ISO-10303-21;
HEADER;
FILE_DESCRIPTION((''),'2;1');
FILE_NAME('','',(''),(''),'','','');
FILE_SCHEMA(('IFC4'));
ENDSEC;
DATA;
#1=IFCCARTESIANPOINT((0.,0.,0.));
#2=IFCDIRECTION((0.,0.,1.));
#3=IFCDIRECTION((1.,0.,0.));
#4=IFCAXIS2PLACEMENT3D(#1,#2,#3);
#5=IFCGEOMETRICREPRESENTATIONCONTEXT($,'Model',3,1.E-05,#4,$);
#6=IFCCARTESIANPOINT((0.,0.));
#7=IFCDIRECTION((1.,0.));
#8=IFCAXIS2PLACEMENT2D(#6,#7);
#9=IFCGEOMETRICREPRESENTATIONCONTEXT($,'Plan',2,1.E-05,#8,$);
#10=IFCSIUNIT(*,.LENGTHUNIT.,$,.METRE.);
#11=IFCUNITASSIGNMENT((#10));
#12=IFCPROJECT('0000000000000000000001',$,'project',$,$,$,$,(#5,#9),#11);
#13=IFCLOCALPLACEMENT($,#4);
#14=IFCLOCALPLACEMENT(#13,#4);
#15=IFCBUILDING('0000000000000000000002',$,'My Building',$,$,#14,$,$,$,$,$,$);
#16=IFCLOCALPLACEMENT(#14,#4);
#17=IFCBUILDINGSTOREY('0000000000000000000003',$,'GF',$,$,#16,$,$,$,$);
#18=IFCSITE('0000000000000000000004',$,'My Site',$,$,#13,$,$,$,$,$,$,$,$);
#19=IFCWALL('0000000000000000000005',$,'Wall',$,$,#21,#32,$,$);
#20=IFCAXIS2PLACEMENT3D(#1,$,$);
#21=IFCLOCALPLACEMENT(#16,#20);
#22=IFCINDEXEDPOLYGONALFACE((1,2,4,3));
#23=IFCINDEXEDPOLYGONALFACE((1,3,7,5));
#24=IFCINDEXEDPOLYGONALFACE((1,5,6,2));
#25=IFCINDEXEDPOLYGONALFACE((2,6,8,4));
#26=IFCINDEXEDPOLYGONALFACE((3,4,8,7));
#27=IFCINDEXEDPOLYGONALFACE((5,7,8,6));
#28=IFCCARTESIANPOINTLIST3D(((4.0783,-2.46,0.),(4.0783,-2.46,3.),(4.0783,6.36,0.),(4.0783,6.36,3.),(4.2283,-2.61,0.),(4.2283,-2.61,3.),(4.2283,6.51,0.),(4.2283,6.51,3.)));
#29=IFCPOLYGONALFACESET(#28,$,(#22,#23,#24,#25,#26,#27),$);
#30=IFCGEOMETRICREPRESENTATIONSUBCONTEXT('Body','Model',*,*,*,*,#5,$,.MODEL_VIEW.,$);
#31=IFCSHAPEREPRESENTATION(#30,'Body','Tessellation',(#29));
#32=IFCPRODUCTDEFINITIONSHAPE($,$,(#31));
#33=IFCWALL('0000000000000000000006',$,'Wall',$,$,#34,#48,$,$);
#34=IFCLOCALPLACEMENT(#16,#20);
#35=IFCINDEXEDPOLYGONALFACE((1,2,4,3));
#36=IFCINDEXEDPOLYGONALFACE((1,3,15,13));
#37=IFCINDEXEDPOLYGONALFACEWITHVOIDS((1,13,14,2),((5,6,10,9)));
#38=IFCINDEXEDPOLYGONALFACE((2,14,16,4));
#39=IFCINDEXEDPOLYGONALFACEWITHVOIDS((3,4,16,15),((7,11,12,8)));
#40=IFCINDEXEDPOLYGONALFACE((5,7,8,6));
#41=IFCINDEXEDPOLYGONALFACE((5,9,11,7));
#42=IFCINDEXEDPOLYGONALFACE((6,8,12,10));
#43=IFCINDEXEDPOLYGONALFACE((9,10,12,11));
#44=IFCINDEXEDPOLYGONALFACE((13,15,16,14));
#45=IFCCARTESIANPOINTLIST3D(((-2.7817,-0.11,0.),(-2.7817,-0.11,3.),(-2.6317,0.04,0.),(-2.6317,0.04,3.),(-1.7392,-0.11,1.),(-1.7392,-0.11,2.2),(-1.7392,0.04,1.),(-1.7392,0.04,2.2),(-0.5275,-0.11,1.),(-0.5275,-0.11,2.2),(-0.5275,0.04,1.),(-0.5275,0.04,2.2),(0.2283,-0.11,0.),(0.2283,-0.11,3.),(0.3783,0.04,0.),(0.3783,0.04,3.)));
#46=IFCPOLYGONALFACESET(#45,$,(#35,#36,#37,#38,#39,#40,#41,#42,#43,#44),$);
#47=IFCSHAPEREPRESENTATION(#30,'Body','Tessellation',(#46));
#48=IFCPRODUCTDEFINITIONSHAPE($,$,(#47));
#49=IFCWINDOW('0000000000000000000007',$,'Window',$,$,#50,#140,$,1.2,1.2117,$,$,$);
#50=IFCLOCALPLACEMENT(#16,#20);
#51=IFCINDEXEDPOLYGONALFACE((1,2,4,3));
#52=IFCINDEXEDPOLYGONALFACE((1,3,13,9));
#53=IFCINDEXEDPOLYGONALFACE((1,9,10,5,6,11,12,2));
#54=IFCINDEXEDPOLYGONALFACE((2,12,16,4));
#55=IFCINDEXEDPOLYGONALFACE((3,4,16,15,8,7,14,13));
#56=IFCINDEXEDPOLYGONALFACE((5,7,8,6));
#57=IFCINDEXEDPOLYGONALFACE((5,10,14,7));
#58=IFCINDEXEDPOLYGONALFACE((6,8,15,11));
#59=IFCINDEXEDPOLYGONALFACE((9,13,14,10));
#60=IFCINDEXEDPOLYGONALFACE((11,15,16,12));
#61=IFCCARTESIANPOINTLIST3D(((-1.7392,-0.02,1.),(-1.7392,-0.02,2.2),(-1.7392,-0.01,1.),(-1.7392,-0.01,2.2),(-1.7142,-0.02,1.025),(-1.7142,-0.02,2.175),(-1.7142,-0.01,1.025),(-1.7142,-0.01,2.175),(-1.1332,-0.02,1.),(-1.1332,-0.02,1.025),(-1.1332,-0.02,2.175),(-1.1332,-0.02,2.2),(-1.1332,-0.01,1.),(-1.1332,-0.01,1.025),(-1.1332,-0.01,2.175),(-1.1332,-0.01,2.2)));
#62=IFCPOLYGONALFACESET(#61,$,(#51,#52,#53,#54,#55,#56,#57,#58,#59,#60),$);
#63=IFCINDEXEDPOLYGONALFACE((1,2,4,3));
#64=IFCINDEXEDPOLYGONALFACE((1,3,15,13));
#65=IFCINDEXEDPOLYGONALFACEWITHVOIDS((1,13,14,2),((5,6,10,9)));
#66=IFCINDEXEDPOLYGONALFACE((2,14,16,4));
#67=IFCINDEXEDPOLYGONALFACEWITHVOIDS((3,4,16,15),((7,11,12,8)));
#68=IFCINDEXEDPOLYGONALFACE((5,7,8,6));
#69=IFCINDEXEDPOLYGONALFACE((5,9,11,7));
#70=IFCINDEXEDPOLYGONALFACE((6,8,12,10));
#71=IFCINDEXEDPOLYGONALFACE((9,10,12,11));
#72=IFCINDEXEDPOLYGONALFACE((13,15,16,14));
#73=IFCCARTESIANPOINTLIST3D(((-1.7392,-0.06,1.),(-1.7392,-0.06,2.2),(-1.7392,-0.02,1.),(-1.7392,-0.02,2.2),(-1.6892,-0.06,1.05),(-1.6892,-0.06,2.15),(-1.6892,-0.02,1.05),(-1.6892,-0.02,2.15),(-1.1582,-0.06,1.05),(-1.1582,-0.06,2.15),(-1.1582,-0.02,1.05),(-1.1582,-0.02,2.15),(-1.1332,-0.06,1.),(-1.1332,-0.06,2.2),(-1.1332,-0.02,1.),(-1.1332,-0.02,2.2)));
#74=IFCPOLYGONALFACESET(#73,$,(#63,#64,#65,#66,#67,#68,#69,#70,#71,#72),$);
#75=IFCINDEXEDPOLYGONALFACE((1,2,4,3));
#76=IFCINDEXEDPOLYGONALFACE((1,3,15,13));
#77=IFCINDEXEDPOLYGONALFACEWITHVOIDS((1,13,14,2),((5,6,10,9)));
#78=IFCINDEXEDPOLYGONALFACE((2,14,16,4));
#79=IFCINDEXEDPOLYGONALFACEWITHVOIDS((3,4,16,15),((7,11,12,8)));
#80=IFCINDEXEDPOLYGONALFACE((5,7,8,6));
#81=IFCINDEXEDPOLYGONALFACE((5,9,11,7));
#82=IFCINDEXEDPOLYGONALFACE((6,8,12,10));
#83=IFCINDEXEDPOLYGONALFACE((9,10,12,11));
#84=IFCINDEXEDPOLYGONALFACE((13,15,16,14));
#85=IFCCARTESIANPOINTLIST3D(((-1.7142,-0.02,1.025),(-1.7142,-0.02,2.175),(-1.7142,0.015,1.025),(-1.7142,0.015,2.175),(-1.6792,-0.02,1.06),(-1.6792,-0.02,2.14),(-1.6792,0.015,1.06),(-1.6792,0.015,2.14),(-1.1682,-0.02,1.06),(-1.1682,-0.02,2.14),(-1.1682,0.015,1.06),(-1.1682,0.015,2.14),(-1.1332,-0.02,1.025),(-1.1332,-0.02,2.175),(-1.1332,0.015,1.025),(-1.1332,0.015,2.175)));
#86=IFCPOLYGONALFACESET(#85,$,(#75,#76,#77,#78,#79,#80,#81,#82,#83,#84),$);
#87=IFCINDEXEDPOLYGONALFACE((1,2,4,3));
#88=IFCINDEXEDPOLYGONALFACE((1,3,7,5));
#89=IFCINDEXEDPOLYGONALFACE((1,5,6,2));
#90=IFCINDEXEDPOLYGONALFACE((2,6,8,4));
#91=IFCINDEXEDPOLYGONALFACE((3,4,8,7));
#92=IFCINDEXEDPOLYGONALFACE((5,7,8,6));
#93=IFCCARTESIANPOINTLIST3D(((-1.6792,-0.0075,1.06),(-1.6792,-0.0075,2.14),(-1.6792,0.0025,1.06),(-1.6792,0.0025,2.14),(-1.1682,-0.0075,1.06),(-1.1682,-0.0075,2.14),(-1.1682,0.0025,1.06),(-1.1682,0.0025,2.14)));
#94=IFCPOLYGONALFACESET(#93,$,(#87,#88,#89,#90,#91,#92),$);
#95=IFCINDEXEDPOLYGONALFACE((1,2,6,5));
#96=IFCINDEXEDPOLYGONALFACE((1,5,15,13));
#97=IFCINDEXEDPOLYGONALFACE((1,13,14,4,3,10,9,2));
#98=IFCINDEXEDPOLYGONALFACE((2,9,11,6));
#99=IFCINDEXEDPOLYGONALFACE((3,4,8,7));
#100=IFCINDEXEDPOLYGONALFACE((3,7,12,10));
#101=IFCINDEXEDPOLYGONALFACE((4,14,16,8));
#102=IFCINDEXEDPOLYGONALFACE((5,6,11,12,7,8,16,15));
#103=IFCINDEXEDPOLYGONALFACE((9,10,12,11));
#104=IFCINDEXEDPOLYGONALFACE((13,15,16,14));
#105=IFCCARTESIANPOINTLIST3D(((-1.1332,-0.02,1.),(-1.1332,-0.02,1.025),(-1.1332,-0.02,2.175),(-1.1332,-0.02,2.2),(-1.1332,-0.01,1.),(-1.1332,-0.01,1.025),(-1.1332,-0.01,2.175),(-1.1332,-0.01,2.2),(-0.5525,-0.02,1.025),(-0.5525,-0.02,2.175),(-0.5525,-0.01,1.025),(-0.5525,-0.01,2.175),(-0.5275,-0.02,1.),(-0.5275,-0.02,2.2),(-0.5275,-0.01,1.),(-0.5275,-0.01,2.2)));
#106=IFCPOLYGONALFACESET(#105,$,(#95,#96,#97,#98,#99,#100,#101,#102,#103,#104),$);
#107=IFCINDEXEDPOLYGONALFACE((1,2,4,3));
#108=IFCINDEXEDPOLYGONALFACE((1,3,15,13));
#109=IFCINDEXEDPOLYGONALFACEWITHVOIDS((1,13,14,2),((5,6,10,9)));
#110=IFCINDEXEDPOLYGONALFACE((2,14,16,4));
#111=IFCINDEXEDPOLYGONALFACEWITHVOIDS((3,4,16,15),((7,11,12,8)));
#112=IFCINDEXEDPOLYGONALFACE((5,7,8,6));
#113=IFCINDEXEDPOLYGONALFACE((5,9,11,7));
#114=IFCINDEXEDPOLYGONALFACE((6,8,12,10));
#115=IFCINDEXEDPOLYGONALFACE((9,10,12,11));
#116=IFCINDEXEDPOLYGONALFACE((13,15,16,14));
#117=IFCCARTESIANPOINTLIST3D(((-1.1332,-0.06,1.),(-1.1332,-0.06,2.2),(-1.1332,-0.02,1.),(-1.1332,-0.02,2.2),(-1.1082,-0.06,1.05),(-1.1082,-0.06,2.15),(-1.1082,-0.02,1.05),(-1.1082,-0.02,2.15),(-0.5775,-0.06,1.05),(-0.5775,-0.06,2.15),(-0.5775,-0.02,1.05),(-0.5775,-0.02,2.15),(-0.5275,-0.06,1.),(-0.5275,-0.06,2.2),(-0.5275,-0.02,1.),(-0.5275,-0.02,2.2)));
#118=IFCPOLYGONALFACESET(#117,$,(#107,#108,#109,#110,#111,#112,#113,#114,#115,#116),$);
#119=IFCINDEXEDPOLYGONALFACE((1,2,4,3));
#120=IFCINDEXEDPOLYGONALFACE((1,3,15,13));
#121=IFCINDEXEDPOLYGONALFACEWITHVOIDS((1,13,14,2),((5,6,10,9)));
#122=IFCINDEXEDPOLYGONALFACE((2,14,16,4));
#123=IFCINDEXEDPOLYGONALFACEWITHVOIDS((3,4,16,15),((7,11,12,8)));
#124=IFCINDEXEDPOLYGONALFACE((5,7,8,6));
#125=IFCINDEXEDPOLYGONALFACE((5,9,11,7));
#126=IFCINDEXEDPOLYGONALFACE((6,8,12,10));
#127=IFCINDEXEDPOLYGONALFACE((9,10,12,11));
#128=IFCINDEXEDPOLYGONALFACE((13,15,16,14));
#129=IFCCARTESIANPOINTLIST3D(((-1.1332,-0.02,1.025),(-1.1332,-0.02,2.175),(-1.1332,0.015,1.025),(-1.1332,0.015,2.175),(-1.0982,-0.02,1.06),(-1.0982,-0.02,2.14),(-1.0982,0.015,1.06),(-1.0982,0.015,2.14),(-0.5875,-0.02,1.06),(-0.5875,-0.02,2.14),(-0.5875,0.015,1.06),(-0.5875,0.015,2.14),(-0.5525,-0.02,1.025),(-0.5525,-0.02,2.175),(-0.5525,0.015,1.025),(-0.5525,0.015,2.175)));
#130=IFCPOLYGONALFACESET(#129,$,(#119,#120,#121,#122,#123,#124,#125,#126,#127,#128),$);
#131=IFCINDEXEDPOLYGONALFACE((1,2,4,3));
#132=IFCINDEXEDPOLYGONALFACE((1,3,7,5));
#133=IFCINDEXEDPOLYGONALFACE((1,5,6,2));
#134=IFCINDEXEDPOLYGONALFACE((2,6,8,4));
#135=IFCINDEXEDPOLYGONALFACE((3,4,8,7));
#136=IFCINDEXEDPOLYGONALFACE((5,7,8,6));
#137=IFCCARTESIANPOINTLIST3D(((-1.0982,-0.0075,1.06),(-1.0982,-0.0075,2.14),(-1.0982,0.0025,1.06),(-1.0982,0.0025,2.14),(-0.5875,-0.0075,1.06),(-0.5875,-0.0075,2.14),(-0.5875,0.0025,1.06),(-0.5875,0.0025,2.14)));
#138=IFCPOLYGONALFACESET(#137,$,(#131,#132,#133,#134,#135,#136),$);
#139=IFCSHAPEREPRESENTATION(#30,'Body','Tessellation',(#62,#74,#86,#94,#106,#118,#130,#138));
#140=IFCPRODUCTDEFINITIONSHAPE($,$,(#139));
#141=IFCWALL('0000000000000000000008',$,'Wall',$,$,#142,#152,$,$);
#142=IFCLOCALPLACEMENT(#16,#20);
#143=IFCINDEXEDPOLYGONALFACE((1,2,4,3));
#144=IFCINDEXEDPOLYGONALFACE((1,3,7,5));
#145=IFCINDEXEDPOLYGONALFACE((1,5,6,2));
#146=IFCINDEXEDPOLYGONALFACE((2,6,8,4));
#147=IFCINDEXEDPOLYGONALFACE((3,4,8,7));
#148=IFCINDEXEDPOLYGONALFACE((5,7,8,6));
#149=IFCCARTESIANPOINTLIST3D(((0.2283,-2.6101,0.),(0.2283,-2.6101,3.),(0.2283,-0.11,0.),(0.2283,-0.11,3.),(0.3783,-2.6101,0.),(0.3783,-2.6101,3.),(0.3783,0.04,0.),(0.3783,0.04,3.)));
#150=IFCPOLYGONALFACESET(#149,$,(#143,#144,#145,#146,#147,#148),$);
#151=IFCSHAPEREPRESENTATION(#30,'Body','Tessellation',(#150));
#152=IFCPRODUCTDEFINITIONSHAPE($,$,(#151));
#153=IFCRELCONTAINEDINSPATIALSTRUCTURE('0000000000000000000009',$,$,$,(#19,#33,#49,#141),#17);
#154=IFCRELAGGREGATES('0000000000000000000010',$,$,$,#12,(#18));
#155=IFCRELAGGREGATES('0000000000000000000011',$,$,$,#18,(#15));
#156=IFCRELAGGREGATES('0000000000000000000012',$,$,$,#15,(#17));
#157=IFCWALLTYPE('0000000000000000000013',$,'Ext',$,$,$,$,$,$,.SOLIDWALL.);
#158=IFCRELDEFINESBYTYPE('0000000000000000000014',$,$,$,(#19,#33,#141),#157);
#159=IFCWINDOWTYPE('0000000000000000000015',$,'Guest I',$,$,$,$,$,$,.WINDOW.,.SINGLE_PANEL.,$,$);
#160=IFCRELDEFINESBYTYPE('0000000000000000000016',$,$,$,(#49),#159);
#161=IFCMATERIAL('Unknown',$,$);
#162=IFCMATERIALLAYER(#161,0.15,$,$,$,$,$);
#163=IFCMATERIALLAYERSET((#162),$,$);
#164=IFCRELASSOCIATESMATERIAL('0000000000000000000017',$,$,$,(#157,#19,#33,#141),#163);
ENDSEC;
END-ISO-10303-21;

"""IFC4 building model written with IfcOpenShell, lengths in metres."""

from ifc_helpers import new_model, entity, si_unit, frame, origin_with_axes, origin_2d_with_axis, place, context, subcontext, project, spatial, line, indexed_curve, outline, extrude, shape, source, transform, mapped, material, layer, layer_set, layer_usage, type_object, type_shapes, element, fill, save


model = new_model("IFC4")

# Units and contexts
model_context = context("Model", 3, precision=1e-05, world=origin_with_axes())
plan_context = context("Plan", 2, precision=1e-05, world=origin_2d_with_axis())
body_context_1 = subcontext(model_context, "Body", "Model", "MODEL_VIEW")
body_context_2 = subcontext(plan_context, "Body", "Plan", "PLAN_VIEW")
ifc_project = project(units=[si_unit("LENGTHUNIT", "METRE")], contexts=[model_context, plan_context])

# Site, building, storey
site_placement = place(None, origin_with_axes())
site = spatial("IfcSite", under=ifc_project, at=site_placement, Name="My Site")
building_placement = place(site_placement, origin_with_axes())
building = spatial("IfcBuilding", under=site, at=building_placement, Name="My Building")
storey_placement = place(building_placement, origin_with_axes())
storey = spatial("IfcBuildingStorey", under=building, at=storey_placement, Name="GF")

# Shared definitions
ifc_material = material(Name="Unknown")

# Shared definitions
ifc_layer_1 = layer(ifc_material, 0.15)
ifc_layer_set_1 = layer_set([ifc_layer_1])
wall_type = type_object("IfcWallType", Name="Ext", PredefinedType="SOLIDWALL", material=ifc_layer_set_1)

# Wall
ifc_layer_usage_1 = layer_usage(ifc_layer_set_1, "AXIS2", "POSITIVE", 0.0)
wall_1_placement = place(storey_placement, frame((4.2283, -2.61, 0.0), z_axis=(0.0, 0.0, 1.0), x_axis=(0.0, 1.0, 0.0)))
element("IfcWall", 1, at=wall_1_placement, inside=storey, type_object=wall_type, material=ifc_layer_usage_1, Name="Wall", context=body_context_1, shape_type="SweptSolid", body=[
    extrude(outline(indexed_curve([(0.0, 0.0), (0.15, 0.15), (8.97, 0.15), (9.12, 0.0)], segments=[line(1, 2, 3, 4, 1)])), origin_with_axes(), (0.0, 0.0, 1.0), 3.0),
])

# Wall, opening, window
ifc_layer_usage_2 = layer_usage(ifc_layer_set_1, "AXIS2", "POSITIVE", 0.0)
wall_2_placement = place(storey_placement, frame((-2.7817, -0.11, 0.0), z_axis=(0.0, 0.0, 1.0), x_axis=(1.0, 0.0, 0.0)))
wall_2 = element("IfcWall", 2, at=wall_2_placement, inside=storey, type_object=wall_type, material=ifc_layer_usage_2, Name="Wall", context=body_context_1, shape_type="SweptSolid", body=[
    extrude(outline(indexed_curve([(0.0, 0.0), (0.15, 0.15), (3.16, 0.15), (3.01, 0.0)], segments=[line(1, 2, 3, 4, 1)])), origin_with_axes(), (0.0, 0.0, 1.0), 3.0),
])
shared_shape_1 = source(origin_with_axes(), body_context_1, "Body", "SweptSolid", [
    extrude(outline(indexed_curve([(0.0, 0.0), (1.2117, 0.0), (1.2117, 1.2), (0.0, 1.2)], segments=[line(1, 2, 3, 4, 1)])), frame((0.0, -0.6, 0.0), z_axis=(0.0, -1.0, 0.0), x_axis=(1.0, 0.0, 0.0)), (0.0, 0.0, -1.0), 1.2),
])
opening_1_placement = place(wall_2_placement, frame((1.0425, 0.0, 1.0), z_axis=(0.0, 0.0, 1.0), x_axis=(1.0, 0.0, 0.0)))
opening_1 = element("IfcOpeningElement", 3, at=opening_1_placement, cuts=wall_2, PredefinedType="OPENING", context=body_context_1, shape_type="MappedRepresentation", body=[
    mapped(shared_shape_1, transform((0.0, 0.0, 0.0), x_axis=(1.0, 0.0, 0.0), y_axis=(0.0, 1.0, 0.0), z_axis=(0.0, 0.0, 1.0), scale=1.0)),
])
window_type_1 = type_object("IfcWindowType", Name="Guest I", PartitioningType="SINGLE_PANEL", PredefinedType="WINDOW")
shared_shape_2 = source(origin_with_axes(), body_context_1, "Body", "SweptSolid", [
    extrude(outline(indexed_curve([(0.606, 0.0), (0.0, 0.0), (0.0, 1.2), (0.606, 1.2), (0.606, 1.175), (0.025, 1.175), (0.025, 0.025), (0.606, 0.025)], segments=[line(1, 2, 3, 4, 5, 6, 7, 8, 1)])), frame((0.0, 0.09, 0.0), z_axis=(0.0, -1.0, 0.0), x_axis=(1.0, 0.0, 0.0)), (0.0, 0.0, -1.0), 0.01),
    extrude(outline(indexed_curve([(0.0, 1.2), (0.606, 1.2), (0.606, 0.0), (0.0, 0.0), (0.0, 1.2)]), holes=[indexed_curve([(0.05, 1.15), (0.581, 1.15), (0.581, 0.05), (0.05, 0.05), (0.05, 1.15)])]), frame((0.0, 0.05, 0.0), z_axis=(0.0, -1.0, 0.0), x_axis=(1.0, 0.0, 0.0)), (0.0, 0.0, -1.0), 0.04),
    extrude(outline(indexed_curve([(0.0, 0.0), (0.581, 0.0), (0.581, 1.15), (0.0, 1.15)], segments=[line(1, 2, 3, 4, 1)]), holes=[indexed_curve([(0.035, 0.035), (0.546, 0.035), (0.546, 1.115), (0.035, 1.115)], segments=[line(1, 2, 3, 4, 1)])]), frame((0.025, 0.09, 0.025), z_axis=(0.0, -1.0, 0.0), x_axis=(1.0, 0.0, 0.0)), (0.0, 0.0, -1.0), 0.035),
    extrude(outline(indexed_curve([(0.035, 0.035), (0.546, 0.035), (0.546, 1.115), (0.035, 1.115)], segments=[line(1, 2, 3, 4, 1)])), frame((0.025, 0.1025, 0.025), z_axis=(0.0, -1.0, 0.0), x_axis=(1.0, 0.0, 0.0)), (0.0, 0.0, -1.0), 0.01),
    extrude(outline(indexed_curve([(0.0, 1.2), (0.6057, 1.2), (0.6057, 0.0), (0.0, 0.0), (0.0, 0.025), (0.5807, 0.025), (0.5807, 1.175), (0.0, 1.175)], segments=[line(1, 2, 3, 4, 5, 6, 7, 8, 1)])), frame((0.606, 0.09, 0.0), z_axis=(0.0, -1.0, 0.0), x_axis=(1.0, 0.0, 0.0)), (0.0, 0.0, -1.0), 0.01),
    extrude(outline(indexed_curve([(0.0, 0.0), (0.6057, 0.0), (0.6057, 1.2), (0.0, 1.2)], segments=[line(1, 2, 3, 4, 1)]), holes=[indexed_curve([(0.025, 0.05), (0.5557, 0.05), (0.5557, 1.15), (0.025, 1.15)], segments=[line(1, 2, 3, 4, 1)])]), frame((0.606, 0.05, 0.0), z_axis=(0.0, -1.0, 0.0), x_axis=(1.0, 0.0, 0.0)), (0.0, 0.0, -1.0), 0.04),
    extrude(outline(indexed_curve([(0.0, 0.0), (0.5807, 0.0), (0.5807, 1.15), (0.0, 1.15)], segments=[line(1, 2, 3, 4, 1)]), holes=[indexed_curve([(0.035, 0.035), (0.5457, 0.035), (0.5457, 1.115), (0.035, 1.115)], segments=[line(1, 2, 3, 4, 1)])]), frame((0.606, 0.09, 0.025), z_axis=(0.0, -1.0, 0.0), x_axis=(1.0, 0.0, 0.0)), (0.0, 0.0, -1.0), 0.035),
    extrude(outline(indexed_curve([(0.035, 0.035), (0.5457, 0.035), (0.5457, 1.115), (0.035, 1.115)], segments=[line(1, 2, 3, 4, 1)])), frame((0.606, 0.1025, 0.025), z_axis=(0.0, -1.0, 0.0), x_axis=(1.0, 0.0, 0.0)), (0.0, 0.0, -1.0), 0.01),
])
shared_shape_3 = source(origin_with_axes(), body_context_2, "Body", "Curve2D", [
    entity("IfcIndexedPolyCurve", entity("IfcCartesianPointList2D", [[0.05, 0.05], [0.581, 0.05]])),
    entity("IfcIndexedPolyCurve", entity("IfcCartesianPointList2D", [[0.0, 0.1], [0.025, 0.1], [0.025, 0.09], [0.05, 0.09], [0.05, 0.05], [0.0, 0.05]]), [entity("IfcLineIndex", [1, 2, 3, 4, 5, 6, 1])]),
    entity("IfcIndexedPolyCurve", entity("IfcCartesianPointList2D", [[0.606, 0.1], [0.606, 0.1], [0.606, 0.09], [0.581, 0.09], [0.581, 0.05], [0.606, 0.05]])),
    entity("IfcIndexedPolyCurve", entity("IfcCartesianPointList2D", [[0.025, 0.09], [0.06, 0.09], [0.06, 0.125], [0.025, 0.125]]), [entity("IfcLineIndex", [1, 2, 3, 4, 1])]),
    entity("IfcIndexedPolyCurve", entity("IfcCartesianPointList2D", [[0.606, 0.09], [0.571, 0.09], [0.571, 0.125], [0.606, 0.125]]), [entity("IfcLineIndex", [1, 2, 3, 4, 1])]),
    entity("IfcIndexedPolyCurve", entity("IfcCartesianPointList2D", [[0.06, 0.09], [0.571, 0.09]])),
    entity("IfcIndexedPolyCurve", entity("IfcCartesianPointList2D", [[0.06, 0.125], [0.571, 0.125]])),
    entity("IfcIndexedPolyCurve", entity("IfcCartesianPointList2D", [[0.06, 0.1075], [0.571, 0.1075]])),
    entity("IfcIndexedPolyCurve", entity("IfcCartesianPointList2D", [[0.631, 0.05], [1.1617, 0.05]])),
    entity("IfcIndexedPolyCurve", entity("IfcCartesianPointList2D", [[0.606, 0.1], [0.606, 0.1], [0.606, 0.09], [0.631, 0.09], [0.631, 0.05], [0.606, 0.05]])),
    entity("IfcIndexedPolyCurve", entity("IfcCartesianPointList2D", [[1.2117, 0.1], [1.1867, 0.1], [1.1867, 0.09], [1.1617, 0.09], [1.1617, 0.05], [1.2117, 0.05]]), [entity("IfcLineIndex", [1, 2, 3, 4, 5, 6, 1])]),
    entity("IfcIndexedPolyCurve", entity("IfcCartesianPointList2D", [[0.606, 0.09], [0.641, 0.09], [0.641, 0.125], [0.606, 0.125]]), [entity("IfcLineIndex", [1, 2, 3, 4, 1])]),
    entity("IfcIndexedPolyCurve", entity("IfcCartesianPointList2D", [[1.1867, 0.09], [1.1517, 0.09], [1.1517, 0.125], [1.1867, 0.125]]), [entity("IfcLineIndex", [1, 2, 3, 4, 1])]),
    entity("IfcIndexedPolyCurve", entity("IfcCartesianPointList2D", [[0.641, 0.09], [1.1517, 0.09]])),
    entity("IfcIndexedPolyCurve", entity("IfcCartesianPointList2D", [[0.641, 0.125], [1.1517, 0.125]])),
    entity("IfcIndexedPolyCurve", entity("IfcCartesianPointList2D", [[0.641, 0.1075], [1.1517, 0.1075]])),
])
type_shapes(window_type_1, [shared_shape_2, shared_shape_3])
window_1_placement = place(opening_1_placement, origin_with_axes())
window_1 = element("IfcWindow", 4, at=window_1_placement, inside=storey, type_object=window_type_1, Name="Window", OverallHeight=1.2, OverallWidth=1.2117, shapes=[
    shape(body_context_1, "Body", "MappedRepresentation", [mapped(shared_shape_2, transform((0.0, 0.0, 0.0), x_axis=(1.0, 0.0, 0.0), y_axis=(0.0, 1.0, 0.0), z_axis=(0.0, 0.0, 1.0), scale=1.0))]),
    shape(body_context_2, "Body", "MappedRepresentation", [mapped(shared_shape_3, transform((0.0, 0.0, 0.0), x_axis=(1.0, 0.0, 0.0), y_axis=(0.0, 1.0, 0.0), z_axis=(0.0, 0.0, 1.0), scale=1.0))]),
])
fill(opening_1, window_1)

# Wall
ifc_layer_usage_3 = layer_usage(ifc_layer_set_1, "AXIS2", "POSITIVE", 0.0)
wall_3_placement = place(storey_placement, frame((0.2283, -0.11, 0.0), z_axis=(0.0, 0.0, 1.0), x_axis=(0.0, -1.0, 0.0)))
element("IfcWall", 5, at=wall_3_placement, inside=storey, type_object=wall_type, material=ifc_layer_usage_3, Name="Wall", context=body_context_1, shape_type="SweptSolid", body=[
    extrude(outline(indexed_curve([(0.0, 0.0), (-0.15, 0.15), (2.5001, 0.15), (2.5001, 0.0)], segments=[line(1, 2, 3, 4, 1)])), origin_with_axes(), (0.0, 0.0, 1.0), 3.0),
])

save(model, "model.ifc")
